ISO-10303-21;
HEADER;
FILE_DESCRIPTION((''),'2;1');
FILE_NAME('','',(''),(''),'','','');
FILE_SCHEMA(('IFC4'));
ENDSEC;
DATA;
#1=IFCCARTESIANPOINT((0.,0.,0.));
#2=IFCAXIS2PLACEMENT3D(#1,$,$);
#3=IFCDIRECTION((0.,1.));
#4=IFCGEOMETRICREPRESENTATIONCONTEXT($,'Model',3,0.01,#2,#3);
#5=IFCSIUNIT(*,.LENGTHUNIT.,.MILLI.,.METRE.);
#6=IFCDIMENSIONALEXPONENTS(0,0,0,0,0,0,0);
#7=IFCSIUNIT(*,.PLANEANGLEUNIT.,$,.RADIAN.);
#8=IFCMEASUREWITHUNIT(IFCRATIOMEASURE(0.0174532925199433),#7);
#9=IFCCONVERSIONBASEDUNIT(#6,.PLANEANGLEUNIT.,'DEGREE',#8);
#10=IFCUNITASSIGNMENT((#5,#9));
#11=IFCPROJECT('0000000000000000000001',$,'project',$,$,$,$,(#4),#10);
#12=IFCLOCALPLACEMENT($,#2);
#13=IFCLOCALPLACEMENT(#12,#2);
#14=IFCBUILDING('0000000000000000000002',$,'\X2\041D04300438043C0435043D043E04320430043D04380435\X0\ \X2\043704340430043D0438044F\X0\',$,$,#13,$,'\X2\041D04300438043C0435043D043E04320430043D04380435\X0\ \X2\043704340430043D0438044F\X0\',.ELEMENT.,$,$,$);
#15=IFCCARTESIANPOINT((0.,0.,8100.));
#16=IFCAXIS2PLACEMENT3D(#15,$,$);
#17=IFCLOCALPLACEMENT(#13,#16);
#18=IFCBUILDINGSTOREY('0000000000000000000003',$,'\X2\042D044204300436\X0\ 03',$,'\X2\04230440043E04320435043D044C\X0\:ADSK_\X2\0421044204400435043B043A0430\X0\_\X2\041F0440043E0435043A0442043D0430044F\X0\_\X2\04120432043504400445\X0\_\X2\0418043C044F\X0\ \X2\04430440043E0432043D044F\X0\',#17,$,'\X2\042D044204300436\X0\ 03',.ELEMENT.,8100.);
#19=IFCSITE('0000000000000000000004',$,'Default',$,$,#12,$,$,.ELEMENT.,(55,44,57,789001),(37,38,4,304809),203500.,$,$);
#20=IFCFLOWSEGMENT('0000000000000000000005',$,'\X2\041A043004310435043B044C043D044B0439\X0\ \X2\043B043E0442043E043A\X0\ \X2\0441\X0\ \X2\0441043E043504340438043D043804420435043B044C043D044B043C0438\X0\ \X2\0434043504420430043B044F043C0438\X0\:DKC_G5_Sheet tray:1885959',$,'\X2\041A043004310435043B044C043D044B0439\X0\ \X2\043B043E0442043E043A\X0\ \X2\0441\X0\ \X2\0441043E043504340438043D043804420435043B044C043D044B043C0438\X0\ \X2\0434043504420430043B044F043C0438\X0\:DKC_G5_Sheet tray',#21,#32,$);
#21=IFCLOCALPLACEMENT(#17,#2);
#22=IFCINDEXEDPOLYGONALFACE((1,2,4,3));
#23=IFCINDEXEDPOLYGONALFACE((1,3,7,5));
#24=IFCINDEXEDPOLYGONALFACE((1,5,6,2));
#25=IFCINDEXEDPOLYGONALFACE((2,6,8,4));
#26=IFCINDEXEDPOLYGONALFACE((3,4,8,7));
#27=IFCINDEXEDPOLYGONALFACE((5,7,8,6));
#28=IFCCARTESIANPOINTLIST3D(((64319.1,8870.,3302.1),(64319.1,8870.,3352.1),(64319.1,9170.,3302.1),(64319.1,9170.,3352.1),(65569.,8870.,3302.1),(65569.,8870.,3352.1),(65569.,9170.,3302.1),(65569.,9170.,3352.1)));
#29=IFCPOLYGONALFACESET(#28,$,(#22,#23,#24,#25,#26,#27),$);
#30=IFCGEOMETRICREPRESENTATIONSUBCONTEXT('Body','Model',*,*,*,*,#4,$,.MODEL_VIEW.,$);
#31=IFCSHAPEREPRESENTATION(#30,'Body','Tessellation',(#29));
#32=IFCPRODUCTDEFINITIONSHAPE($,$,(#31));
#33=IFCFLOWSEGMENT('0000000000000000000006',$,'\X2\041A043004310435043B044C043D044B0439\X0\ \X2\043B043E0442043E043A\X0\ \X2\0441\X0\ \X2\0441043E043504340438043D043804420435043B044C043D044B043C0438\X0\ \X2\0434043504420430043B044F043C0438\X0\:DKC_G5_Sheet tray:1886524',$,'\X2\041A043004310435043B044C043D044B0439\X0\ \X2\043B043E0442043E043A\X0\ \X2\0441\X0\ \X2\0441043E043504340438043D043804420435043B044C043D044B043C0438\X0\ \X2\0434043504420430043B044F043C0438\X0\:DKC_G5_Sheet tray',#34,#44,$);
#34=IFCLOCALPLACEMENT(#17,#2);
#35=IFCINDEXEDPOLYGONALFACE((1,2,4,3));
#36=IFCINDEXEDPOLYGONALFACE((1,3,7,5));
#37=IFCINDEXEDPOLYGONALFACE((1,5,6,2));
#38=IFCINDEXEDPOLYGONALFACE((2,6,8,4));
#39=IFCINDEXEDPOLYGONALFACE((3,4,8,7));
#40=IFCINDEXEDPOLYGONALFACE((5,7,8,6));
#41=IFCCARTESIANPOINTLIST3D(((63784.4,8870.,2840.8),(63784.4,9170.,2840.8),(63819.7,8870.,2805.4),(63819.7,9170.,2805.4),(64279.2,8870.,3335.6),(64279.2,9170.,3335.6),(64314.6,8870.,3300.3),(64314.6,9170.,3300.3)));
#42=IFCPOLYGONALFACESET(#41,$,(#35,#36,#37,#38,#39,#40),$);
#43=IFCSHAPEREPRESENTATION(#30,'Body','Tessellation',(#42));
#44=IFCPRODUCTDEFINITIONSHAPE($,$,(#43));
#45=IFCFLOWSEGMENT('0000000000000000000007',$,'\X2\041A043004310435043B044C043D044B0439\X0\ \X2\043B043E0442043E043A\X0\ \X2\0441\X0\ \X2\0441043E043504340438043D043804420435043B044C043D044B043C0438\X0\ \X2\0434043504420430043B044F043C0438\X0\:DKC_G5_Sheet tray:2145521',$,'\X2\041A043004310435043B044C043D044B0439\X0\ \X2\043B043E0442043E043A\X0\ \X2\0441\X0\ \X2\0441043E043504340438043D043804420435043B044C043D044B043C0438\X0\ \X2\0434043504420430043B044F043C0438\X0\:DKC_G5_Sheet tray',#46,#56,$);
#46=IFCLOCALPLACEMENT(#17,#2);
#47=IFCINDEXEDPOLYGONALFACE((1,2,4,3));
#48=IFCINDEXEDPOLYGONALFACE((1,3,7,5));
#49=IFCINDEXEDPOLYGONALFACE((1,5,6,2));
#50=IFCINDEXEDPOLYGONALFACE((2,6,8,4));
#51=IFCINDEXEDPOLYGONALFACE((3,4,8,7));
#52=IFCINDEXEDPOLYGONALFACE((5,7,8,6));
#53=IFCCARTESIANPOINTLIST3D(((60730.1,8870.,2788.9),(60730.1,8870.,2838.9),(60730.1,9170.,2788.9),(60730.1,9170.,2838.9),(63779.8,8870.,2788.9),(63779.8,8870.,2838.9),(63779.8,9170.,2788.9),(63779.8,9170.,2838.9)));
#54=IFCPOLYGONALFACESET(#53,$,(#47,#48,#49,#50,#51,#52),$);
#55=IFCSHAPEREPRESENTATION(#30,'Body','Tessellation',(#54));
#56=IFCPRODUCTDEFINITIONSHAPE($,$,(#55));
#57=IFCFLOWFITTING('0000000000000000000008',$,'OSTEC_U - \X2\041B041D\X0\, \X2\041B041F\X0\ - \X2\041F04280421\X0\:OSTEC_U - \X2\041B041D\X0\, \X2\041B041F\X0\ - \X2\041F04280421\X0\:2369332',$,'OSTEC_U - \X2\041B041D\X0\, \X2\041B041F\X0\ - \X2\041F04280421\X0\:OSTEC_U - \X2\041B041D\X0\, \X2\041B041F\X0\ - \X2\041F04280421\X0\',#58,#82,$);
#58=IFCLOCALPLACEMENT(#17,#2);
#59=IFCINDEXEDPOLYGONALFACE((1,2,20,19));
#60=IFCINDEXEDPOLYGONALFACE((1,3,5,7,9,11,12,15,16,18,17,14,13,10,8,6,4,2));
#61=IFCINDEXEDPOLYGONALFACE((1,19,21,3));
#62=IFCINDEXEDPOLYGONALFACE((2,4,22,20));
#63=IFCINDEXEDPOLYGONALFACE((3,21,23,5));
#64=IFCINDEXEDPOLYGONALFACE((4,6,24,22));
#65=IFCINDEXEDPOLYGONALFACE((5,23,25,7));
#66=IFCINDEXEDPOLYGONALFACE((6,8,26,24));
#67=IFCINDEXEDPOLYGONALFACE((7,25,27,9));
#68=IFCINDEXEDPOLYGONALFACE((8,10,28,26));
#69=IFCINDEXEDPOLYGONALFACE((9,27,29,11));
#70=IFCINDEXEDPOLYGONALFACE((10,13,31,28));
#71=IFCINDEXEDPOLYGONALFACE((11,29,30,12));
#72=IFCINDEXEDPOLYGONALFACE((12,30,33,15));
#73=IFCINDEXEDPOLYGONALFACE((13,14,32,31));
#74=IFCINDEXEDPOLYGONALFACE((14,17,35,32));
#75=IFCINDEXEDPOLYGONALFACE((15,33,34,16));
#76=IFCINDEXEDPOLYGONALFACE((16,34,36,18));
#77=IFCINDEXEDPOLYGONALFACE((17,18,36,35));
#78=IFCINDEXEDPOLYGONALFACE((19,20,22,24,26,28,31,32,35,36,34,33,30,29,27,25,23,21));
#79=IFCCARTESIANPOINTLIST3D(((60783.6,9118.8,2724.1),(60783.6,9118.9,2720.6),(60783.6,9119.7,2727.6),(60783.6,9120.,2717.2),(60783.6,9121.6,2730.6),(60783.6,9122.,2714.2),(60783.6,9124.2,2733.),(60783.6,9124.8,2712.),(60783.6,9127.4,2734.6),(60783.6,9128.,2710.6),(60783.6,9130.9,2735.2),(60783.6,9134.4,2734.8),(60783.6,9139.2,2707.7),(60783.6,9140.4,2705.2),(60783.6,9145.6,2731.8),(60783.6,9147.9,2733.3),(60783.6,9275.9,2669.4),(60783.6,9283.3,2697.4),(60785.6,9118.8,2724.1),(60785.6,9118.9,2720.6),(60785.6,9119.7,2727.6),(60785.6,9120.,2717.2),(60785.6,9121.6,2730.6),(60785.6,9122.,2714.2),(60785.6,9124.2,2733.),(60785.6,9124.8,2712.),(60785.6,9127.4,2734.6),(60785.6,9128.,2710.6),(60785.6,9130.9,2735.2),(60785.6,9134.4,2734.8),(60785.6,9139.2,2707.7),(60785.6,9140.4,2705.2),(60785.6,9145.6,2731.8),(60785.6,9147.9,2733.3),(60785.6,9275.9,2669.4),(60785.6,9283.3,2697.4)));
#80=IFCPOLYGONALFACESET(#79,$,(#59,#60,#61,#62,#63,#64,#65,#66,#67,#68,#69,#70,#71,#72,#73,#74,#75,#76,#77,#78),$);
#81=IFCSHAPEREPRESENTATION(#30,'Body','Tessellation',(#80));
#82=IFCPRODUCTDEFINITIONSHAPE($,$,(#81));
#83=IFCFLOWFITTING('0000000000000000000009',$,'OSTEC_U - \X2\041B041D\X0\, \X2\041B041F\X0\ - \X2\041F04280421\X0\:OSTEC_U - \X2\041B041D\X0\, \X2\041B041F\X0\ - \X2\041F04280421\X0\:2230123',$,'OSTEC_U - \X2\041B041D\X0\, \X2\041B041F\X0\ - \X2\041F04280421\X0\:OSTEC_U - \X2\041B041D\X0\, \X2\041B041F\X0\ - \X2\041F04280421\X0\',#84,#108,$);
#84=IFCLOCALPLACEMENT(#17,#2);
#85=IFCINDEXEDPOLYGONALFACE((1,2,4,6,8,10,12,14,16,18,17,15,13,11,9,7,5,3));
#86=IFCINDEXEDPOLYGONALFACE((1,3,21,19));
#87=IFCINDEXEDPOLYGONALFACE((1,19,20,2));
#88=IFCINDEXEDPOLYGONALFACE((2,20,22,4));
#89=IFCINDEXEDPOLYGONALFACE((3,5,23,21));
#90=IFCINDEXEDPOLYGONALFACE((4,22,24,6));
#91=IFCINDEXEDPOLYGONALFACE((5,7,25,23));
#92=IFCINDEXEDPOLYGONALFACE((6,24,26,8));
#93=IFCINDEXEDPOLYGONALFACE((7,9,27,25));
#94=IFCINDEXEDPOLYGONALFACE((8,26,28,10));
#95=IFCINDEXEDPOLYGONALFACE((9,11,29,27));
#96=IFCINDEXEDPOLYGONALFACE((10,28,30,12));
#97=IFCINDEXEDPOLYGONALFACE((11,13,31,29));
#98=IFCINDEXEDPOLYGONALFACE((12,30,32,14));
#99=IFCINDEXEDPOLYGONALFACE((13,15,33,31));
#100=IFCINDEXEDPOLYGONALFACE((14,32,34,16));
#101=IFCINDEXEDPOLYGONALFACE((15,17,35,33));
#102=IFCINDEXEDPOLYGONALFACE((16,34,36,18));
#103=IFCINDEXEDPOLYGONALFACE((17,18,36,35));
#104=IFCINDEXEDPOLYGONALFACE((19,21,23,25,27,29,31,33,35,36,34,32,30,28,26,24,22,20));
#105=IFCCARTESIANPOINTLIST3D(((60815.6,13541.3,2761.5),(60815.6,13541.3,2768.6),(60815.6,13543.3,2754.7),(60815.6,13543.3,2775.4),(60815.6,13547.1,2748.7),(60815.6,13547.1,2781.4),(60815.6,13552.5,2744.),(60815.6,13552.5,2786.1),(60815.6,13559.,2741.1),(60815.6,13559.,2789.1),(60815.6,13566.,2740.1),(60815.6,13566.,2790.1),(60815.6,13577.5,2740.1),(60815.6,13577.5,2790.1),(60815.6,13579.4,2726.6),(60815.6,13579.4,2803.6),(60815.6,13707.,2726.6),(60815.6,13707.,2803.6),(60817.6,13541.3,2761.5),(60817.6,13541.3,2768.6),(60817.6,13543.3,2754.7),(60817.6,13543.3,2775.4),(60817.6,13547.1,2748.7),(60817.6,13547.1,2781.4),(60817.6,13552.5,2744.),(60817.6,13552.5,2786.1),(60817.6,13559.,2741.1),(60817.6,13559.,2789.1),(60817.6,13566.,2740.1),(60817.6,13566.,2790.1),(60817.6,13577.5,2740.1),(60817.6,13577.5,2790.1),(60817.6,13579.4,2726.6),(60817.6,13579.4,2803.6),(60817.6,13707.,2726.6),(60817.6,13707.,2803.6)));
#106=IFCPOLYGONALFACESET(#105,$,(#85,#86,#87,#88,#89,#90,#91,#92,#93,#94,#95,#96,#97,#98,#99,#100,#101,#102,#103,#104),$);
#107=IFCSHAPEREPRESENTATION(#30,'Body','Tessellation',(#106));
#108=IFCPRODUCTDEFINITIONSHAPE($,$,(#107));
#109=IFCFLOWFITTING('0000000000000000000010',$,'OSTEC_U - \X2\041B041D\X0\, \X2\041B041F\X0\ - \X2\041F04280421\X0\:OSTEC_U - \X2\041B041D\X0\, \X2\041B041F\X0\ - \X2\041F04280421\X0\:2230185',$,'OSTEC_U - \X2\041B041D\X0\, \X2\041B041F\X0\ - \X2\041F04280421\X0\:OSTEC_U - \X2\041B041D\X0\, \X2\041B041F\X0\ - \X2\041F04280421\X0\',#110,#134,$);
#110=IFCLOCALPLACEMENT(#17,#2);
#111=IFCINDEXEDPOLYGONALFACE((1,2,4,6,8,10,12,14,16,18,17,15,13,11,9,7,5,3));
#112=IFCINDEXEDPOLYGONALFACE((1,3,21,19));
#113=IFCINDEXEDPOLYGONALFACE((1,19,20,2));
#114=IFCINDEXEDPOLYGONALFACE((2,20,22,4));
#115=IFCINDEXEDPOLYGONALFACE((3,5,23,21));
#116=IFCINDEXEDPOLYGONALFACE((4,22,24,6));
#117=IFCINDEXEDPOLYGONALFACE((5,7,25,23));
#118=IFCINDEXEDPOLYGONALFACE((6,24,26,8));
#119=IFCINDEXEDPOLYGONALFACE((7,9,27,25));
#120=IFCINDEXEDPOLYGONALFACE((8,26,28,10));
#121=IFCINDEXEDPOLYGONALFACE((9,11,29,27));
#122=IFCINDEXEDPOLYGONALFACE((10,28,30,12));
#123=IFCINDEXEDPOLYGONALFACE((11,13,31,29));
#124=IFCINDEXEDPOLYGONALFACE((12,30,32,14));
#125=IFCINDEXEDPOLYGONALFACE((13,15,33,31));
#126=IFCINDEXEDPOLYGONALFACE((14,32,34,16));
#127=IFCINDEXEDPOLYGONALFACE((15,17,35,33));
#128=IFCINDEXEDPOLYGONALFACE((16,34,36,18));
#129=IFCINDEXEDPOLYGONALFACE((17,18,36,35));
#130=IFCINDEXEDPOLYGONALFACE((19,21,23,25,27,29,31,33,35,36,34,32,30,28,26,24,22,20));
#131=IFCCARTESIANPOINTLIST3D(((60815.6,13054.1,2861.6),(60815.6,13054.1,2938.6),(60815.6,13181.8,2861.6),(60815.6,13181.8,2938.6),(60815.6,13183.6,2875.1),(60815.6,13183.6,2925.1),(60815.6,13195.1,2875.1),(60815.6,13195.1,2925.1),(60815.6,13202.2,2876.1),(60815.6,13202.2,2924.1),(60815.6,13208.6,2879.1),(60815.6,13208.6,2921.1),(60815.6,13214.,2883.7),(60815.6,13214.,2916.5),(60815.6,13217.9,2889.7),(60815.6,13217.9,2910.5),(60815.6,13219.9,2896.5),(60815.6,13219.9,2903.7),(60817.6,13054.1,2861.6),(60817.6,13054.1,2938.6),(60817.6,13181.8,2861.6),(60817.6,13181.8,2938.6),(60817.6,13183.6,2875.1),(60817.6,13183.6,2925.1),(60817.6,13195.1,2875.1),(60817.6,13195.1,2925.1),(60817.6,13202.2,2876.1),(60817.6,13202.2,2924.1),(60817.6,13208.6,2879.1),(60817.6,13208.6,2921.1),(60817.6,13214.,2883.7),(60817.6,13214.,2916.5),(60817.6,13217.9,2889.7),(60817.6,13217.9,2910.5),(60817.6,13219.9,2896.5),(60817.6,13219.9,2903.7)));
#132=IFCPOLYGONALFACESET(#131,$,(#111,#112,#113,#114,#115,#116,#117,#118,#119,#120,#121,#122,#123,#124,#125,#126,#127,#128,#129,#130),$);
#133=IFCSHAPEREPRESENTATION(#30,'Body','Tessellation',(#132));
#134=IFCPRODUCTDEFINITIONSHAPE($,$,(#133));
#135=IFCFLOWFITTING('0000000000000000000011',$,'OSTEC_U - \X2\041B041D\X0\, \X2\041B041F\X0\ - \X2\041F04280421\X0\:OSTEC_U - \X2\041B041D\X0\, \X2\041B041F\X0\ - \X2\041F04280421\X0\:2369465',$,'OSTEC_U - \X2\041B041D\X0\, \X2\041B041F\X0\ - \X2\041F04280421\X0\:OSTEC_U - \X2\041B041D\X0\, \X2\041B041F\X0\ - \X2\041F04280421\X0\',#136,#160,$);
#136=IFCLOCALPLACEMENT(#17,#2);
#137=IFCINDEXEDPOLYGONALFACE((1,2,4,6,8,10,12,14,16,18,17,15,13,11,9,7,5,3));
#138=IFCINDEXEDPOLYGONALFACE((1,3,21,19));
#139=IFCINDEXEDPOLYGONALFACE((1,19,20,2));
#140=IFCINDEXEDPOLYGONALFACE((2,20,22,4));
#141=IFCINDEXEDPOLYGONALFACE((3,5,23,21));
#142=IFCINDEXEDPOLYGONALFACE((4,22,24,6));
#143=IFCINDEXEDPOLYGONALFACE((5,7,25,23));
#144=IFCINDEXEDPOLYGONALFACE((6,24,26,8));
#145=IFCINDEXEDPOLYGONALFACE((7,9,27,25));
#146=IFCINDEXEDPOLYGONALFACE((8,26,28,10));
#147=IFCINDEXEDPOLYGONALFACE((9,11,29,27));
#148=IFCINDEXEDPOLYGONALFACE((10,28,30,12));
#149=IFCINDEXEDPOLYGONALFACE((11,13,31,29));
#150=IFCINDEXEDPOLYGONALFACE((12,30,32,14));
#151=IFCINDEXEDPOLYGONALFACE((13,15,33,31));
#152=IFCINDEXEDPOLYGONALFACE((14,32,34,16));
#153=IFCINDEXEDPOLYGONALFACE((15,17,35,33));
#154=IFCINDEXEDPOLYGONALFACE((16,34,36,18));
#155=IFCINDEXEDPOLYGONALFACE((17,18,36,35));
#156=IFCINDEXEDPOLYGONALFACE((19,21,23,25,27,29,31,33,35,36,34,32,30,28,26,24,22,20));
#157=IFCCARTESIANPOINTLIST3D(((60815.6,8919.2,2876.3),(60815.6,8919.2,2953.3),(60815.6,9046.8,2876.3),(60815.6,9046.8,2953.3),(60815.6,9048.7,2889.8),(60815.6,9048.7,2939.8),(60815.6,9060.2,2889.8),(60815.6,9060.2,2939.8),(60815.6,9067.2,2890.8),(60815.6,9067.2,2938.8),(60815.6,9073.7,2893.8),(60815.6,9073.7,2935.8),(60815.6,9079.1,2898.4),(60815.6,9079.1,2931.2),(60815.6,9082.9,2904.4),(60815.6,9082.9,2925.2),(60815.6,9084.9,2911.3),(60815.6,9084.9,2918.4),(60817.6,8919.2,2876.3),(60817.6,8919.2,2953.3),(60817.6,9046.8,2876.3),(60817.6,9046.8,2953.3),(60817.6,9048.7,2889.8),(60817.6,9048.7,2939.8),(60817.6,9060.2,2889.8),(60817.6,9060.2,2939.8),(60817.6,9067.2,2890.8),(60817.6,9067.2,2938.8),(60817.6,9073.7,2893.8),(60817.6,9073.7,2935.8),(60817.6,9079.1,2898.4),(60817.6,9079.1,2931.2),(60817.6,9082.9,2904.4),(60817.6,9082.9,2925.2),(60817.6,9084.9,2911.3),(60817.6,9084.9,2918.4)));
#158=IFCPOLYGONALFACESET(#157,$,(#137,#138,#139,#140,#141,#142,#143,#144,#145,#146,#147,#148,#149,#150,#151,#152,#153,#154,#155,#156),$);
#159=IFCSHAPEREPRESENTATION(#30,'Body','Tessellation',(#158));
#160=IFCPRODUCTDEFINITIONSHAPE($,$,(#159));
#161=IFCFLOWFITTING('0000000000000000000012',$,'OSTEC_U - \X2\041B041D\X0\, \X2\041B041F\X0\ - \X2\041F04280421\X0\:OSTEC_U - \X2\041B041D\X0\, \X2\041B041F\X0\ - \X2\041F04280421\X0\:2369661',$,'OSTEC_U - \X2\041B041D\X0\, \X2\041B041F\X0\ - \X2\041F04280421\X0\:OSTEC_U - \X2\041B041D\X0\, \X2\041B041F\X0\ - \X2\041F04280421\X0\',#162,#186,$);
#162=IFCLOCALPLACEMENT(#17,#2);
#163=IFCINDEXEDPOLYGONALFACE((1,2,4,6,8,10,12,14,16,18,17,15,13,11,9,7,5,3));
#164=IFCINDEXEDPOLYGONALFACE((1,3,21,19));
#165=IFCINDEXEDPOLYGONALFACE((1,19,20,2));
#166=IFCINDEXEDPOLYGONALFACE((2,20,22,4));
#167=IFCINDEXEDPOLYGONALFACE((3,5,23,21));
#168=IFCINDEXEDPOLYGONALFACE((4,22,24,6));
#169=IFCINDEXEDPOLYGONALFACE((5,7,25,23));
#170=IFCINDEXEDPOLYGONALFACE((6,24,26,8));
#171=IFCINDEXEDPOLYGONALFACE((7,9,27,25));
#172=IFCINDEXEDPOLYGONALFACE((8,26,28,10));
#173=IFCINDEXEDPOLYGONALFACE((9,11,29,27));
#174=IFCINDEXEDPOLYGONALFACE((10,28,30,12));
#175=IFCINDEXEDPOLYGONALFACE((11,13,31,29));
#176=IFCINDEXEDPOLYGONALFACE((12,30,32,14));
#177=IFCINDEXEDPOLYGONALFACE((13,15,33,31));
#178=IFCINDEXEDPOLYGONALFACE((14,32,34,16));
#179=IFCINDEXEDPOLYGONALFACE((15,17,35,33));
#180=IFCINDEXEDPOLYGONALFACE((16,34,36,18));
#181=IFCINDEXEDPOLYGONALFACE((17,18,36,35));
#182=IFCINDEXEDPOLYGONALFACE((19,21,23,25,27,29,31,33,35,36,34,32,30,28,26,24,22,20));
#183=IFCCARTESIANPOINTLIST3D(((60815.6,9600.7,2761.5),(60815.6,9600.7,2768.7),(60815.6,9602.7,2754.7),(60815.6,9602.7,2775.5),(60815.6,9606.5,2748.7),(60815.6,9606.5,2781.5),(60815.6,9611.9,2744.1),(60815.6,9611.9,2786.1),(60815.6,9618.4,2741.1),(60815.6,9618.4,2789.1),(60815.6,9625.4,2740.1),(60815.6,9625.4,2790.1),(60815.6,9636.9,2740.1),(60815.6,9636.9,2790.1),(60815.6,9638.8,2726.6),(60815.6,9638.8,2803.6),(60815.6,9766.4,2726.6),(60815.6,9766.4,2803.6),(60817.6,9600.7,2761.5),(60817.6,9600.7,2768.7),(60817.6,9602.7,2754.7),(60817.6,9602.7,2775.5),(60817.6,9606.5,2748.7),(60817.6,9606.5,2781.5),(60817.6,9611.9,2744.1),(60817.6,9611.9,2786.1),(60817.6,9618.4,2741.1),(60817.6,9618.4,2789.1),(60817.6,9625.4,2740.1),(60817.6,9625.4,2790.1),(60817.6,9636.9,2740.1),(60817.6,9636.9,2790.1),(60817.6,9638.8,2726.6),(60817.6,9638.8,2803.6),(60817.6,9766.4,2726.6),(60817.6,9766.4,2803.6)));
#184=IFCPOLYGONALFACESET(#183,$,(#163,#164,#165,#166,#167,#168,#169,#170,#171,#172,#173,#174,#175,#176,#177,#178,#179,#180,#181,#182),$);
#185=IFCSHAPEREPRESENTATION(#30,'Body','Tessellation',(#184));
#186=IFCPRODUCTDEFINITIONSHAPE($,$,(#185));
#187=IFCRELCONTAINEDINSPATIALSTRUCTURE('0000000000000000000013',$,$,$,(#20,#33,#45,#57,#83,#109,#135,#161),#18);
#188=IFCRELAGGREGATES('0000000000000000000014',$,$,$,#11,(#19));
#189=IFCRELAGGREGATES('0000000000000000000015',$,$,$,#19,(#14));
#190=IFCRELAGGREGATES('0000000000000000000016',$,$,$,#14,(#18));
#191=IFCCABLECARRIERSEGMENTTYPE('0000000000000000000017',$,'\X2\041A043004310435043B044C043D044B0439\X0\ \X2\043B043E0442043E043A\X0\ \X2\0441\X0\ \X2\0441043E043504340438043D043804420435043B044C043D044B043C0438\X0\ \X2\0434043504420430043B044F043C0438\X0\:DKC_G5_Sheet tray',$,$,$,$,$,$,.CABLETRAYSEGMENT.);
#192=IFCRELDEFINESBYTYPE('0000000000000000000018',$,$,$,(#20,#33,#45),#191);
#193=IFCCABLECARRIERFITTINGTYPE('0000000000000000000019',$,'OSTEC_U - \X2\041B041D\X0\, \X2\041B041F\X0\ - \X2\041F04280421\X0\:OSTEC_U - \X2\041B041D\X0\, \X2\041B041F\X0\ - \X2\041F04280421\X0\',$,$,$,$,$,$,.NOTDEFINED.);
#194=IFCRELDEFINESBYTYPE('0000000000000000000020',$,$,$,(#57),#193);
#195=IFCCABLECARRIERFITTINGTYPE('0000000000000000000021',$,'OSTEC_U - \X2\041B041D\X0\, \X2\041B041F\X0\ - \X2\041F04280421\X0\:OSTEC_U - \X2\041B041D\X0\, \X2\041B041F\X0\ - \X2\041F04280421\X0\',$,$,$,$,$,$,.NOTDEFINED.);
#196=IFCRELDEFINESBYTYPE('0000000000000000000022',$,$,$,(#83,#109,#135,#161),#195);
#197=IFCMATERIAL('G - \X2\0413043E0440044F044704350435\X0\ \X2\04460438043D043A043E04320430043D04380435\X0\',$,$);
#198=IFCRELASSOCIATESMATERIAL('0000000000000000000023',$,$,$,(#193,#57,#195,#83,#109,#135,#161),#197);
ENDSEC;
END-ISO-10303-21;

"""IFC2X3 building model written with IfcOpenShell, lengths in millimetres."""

from ifc_helpers import new_model, entity, si_unit, converted_unit, direction, frame, frame_2d, origin, place, context, subcontext, project, spatial, polyline, circle_curve, parameter, trimmed, segment, composite_curve, rectangle, outline, extrude, source, transform, mapped, material, type_object, type_shapes, element, save


model = new_model("IFC2X3")

# Units and contexts
model_context = context("Model", 3, precision=0.01, world=origin(), true_north=direction((0.0, 1.0)))
body_context = subcontext(model_context, "Body", "Model", "MODEL_VIEW")
ifc_project = project(units=[si_unit("LENGTHUNIT", "METRE", prefix="MILLI"), converted_unit("PLANEANGLEUNIT", "DEGREE", entity("IfcRatioMeasure", 0.0174532925199433), si_unit("PLANEANGLEUNIT", "RADIAN"), dimensions=[0, 0, 0, 0, 0, 0, 0])], contexts=[model_context])

# Site, building, storey
site_placement = place(None, frame((0.0, 0.0, 0.0)))
site = spatial("IfcSite", under=ifc_project, at=site_placement, Name="Default", CompositionType="ELEMENT", RefLatitude=(55, 44, 57, 789001), RefLongitude=(37, 38, 4, 304809), RefElevation=203500.0)
building_placement = place(site_placement, origin())
building = spatial("IfcBuilding", under=site, at=building_placement, Name="Наименование здания", LongName="Наименование здания", CompositionType="ELEMENT")
storey_placement = place(building_placement, frame((0.0, 0.0, 8100.0)))
storey = spatial("IfcBuildingStorey", under=building, at=storey_placement, Name="Этаж 03", ObjectType="Уровень:ADSK_Стрелка_Проектная_Вверх_Имя уровня", LongName="Этаж 03", CompositionType="ELEMENT", Elevation=8100.0)

# Flow segments
cable_carrier_segment_type = type_object("IfcCableCarrierSegmentType", Name="Кабельный лоток с соединительными деталями:DKC_G5_Sheet tray", PredefinedType="CABLETRAYSEGMENT")
flow_segment_1_placement = place(storey_placement, frame((64319.1, 8870.0, 3302.1)))
element("IfcFlowSegment", 1, at=flow_segment_1_placement, inside=storey, type_object=cable_carrier_segment_type, Name="Кабельный лоток с соединительными деталями:DKC_G5_Sheet tray:1885959", ObjectType="Кабельный лоток с соединительными деталями:DKC_G5_Sheet tray", context=body_context, shape_type="SweptSolid", body=[
    extrude(rectangle(XDim=1249.9, YDim=300.0, at=frame_2d((0.0, 0.0), x_axis=(1.0, 0.0))), frame((624.9, 150.0, 0.0), z_axis=(0.0, 0.0, 1.0), x_axis=(-1.0, 0.0, 0.0)), (0.0, 0.0, 1.0), 50.0),
])
flow_segment_2_placement = place(storey_placement, frame((63784.4, 8870.0, 2805.4)))
element("IfcFlowSegment", 2, at=flow_segment_2_placement, inside=storey, type_object=cable_carrier_segment_type, Name="Кабельный лоток с соединительными деталями:DKC_G5_Sheet tray:1886524", ObjectType="Кабельный лоток с соединительными деталями:DKC_G5_Sheet tray", context=body_context, shape_type="SweptSolid", body=[
    extrude(rectangle(XDim=50.0, YDim=300.0, at=frame_2d((0.0, 0.0), x_axis=(1.0, 0.0))), frame((17.7, 150.0, 17.7), z_axis=(0.707107, 0.0, 0.707107), x_axis=(-0.707107, 0.0, 0.707107)), (0.0, 0.0, 1.0), 699.8),
])
flow_segment_3_placement = place(storey_placement, frame((60730.1, 8870.0, 2788.9)))
element("IfcFlowSegment", 3, at=flow_segment_3_placement, inside=storey, type_object=cable_carrier_segment_type, Name="Кабельный лоток с соединительными деталями:DKC_G5_Sheet tray:2145521", ObjectType="Кабельный лоток с соединительными деталями:DKC_G5_Sheet tray", context=body_context, shape_type="SweptSolid", body=[
    extrude(rectangle(XDim=3049.7, YDim=300.0, at=frame_2d((0.0, 0.0), x_axis=(1.0, 0.0))), frame((1524.9, 150.0, 0.0)), (0.0, 0.0, 1.0), 50.0),
])

# Flow fittings
ifc_material_1 = material(Name="G - Горячее цинкование")
cable_carrier_fitting_type_1 = type_object("IfcCableCarrierFittingType", Name="OSTEC_U - ЛН, ЛП - ПШС:OSTEC_U - ЛН, ЛП - ПШС", PredefinedType="NOTDEFINED", material=ifc_material_1)
shared_shape_1 = source(origin(), body_context, "Body", "SweptSolid", [
    extrude(outline(composite_curve([segment(trimmed(circle_curve(frame_2d((-44.6, 0.0), x_axis=(1.0, 0.0)), 12.5), [parameter(90.0)], [parameter(270.0)], True, "PARAMETER"), True, "CONTINUOUS"), segment(polyline([(-44.6, -12.5), (-33.1, -12.5)]), True, "CONTINUOUS"), segment(polyline([(-33.1, -12.5), (-31.2, -14.5)]), True, "CONTINUOUS"), segment(polyline([(-31.2, -14.5), (108.9, -14.5)]), True, "CONTINUOUS"), segment(polyline([(108.9, -14.5), (108.9, 14.5)]), True, "CONTINUOUS"), segment(polyline([(108.9, 14.5), (-31.2, 14.5)]), True, "CONTINUOUS"), segment(polyline([(-31.2, 14.5), (-33.1, 12.5)]), True, "CONTINUOUS"), segment(polyline([(-33.1, 12.5), (-44.6, 12.5)]), True, "CONTINUOUS")], self_intersect=False)), frame((44.6, 0.0, 0.0)), (0.0, 0.0, 1.0), 2.0),
])
type_shapes(cable_carrier_fitting_type_1, [shared_shape_1])
for number, where, z_axis, x_axis, name in (
    (4, (60783.6, 9131.2, 2722.7), (1.0, 0.0, 0.0), (0.0, 0.966668, -0.256034), "OSTEC_U - ЛН, ЛП - ПШС:OSTEC_U - ЛН, ЛП - ПШС:2369332"),
):
    element("IfcFlowFitting", number, at=place(storey_placement, frame(where, z_axis=z_axis, x_axis=x_axis)), inside=storey, type_object=cable_carrier_fitting_type_1, material=ifc_material_1, Name=name, ObjectType="OSTEC_U - ЛН, ЛП - ПШС:OSTEC_U - ЛН, ЛП - ПШС", context=body_context, shape_type="MappedRepresentation", body=[
        mapped(shared_shape_1, transform((0.0, 0.0, 0.0), scale=1.0)),
    ])
cable_carrier_fitting_type_2 = type_object("IfcCableCarrierFittingType", Name="OSTEC_U - ЛН, ЛП - ПШС:OSTEC_U - ЛН, ЛП - ПШС", PredefinedType="NOTDEFINED", material=ifc_material_1)
shared_shape_2 = source(origin(), body_context, "Body", "SweptSolid", [
    extrude(outline(composite_curve([segment(trimmed(circle_curve(frame_2d((-41.5, 0.0), x_axis=(1.0, 0.0)), 25.0), [parameter(90.0)], [parameter(270.0)], True, "PARAMETER"), True, "CONTINUOUS"), segment(polyline([(-41.5, -25.0), (-30.0, -25.0)]), True, "CONTINUOUS"), segment(polyline([(-30.0, -25.0), (-28.1, -38.5)]), True, "CONTINUOUS"), segment(polyline([(-28.1, -38.5), (99.5, -38.5)]), True, "CONTINUOUS"), segment(polyline([(99.5, -38.5), (99.5, 38.5)]), True, "CONTINUOUS"), segment(polyline([(99.5, 38.5), (-28.1, 38.5)]), True, "CONTINUOUS"), segment(polyline([(-28.1, 38.5), (-30.0, 25.0)]), True, "CONTINUOUS"), segment(polyline([(-30.0, 25.0), (-41.5, 25.0)]), True, "CONTINUOUS")], self_intersect=False)), frame((41.5, 0.0, 0.0), z_axis=(0.0, 0.0, -1.0), x_axis=(1.0, 0.0, 0.0)), (0.0, 0.0, -1.0), 2.0),
])
type_shapes(cable_carrier_fitting_type_2, [shared_shape_2])
for number, where, z_axis, x_axis, name in (
    (5, (60815.6, 13566.0, 2765.1), (1.0, 0.0, 0.0), (0.0, 1.0, 0.000034), "OSTEC_U - ЛН, ЛП - ПШС:OSTEC_U - ЛН, ЛП - ПШС:2230123"),
    (6, (60815.6, 13195.1, 2900.1), (1.0, 0.0, 0.0), (0.0, -1.0, 0.0), "OSTEC_U - ЛН, ЛП - ПШС:OSTEC_U - ЛН, ЛП - ПШС:2230185"),
    (7, (60815.6, 9060.2, 2914.8), (1.0, 0.0, 0.0), (0.0, -1.0, 0.0), "OSTEC_U - ЛН, ЛП - ПШС:OSTEC_U - ЛН, ЛП - ПШС:2369465"),
    (8, (60815.6, 9625.4, 2765.1), (1.0, 0.0, 0.0), (0.0, 1.0, -0.000005), "OSTEC_U - ЛН, ЛП - ПШС:OSTEC_U - ЛН, ЛП - ПШС:2369661"),
):
    element("IfcFlowFitting", number, at=place(storey_placement, frame(where, z_axis=z_axis, x_axis=x_axis)), inside=storey, type_object=cable_carrier_fitting_type_2, material=ifc_material_1, Name=name, ObjectType="OSTEC_U - ЛН, ЛП - ПШС:OSTEC_U - ЛН, ЛП - ПШС", context=body_context, shape_type="MappedRepresentation", body=[
        mapped(shared_shape_2, transform((0.0, 0.0, 0.0), scale=1.0)),
    ])

save(model, "model.ifc")
